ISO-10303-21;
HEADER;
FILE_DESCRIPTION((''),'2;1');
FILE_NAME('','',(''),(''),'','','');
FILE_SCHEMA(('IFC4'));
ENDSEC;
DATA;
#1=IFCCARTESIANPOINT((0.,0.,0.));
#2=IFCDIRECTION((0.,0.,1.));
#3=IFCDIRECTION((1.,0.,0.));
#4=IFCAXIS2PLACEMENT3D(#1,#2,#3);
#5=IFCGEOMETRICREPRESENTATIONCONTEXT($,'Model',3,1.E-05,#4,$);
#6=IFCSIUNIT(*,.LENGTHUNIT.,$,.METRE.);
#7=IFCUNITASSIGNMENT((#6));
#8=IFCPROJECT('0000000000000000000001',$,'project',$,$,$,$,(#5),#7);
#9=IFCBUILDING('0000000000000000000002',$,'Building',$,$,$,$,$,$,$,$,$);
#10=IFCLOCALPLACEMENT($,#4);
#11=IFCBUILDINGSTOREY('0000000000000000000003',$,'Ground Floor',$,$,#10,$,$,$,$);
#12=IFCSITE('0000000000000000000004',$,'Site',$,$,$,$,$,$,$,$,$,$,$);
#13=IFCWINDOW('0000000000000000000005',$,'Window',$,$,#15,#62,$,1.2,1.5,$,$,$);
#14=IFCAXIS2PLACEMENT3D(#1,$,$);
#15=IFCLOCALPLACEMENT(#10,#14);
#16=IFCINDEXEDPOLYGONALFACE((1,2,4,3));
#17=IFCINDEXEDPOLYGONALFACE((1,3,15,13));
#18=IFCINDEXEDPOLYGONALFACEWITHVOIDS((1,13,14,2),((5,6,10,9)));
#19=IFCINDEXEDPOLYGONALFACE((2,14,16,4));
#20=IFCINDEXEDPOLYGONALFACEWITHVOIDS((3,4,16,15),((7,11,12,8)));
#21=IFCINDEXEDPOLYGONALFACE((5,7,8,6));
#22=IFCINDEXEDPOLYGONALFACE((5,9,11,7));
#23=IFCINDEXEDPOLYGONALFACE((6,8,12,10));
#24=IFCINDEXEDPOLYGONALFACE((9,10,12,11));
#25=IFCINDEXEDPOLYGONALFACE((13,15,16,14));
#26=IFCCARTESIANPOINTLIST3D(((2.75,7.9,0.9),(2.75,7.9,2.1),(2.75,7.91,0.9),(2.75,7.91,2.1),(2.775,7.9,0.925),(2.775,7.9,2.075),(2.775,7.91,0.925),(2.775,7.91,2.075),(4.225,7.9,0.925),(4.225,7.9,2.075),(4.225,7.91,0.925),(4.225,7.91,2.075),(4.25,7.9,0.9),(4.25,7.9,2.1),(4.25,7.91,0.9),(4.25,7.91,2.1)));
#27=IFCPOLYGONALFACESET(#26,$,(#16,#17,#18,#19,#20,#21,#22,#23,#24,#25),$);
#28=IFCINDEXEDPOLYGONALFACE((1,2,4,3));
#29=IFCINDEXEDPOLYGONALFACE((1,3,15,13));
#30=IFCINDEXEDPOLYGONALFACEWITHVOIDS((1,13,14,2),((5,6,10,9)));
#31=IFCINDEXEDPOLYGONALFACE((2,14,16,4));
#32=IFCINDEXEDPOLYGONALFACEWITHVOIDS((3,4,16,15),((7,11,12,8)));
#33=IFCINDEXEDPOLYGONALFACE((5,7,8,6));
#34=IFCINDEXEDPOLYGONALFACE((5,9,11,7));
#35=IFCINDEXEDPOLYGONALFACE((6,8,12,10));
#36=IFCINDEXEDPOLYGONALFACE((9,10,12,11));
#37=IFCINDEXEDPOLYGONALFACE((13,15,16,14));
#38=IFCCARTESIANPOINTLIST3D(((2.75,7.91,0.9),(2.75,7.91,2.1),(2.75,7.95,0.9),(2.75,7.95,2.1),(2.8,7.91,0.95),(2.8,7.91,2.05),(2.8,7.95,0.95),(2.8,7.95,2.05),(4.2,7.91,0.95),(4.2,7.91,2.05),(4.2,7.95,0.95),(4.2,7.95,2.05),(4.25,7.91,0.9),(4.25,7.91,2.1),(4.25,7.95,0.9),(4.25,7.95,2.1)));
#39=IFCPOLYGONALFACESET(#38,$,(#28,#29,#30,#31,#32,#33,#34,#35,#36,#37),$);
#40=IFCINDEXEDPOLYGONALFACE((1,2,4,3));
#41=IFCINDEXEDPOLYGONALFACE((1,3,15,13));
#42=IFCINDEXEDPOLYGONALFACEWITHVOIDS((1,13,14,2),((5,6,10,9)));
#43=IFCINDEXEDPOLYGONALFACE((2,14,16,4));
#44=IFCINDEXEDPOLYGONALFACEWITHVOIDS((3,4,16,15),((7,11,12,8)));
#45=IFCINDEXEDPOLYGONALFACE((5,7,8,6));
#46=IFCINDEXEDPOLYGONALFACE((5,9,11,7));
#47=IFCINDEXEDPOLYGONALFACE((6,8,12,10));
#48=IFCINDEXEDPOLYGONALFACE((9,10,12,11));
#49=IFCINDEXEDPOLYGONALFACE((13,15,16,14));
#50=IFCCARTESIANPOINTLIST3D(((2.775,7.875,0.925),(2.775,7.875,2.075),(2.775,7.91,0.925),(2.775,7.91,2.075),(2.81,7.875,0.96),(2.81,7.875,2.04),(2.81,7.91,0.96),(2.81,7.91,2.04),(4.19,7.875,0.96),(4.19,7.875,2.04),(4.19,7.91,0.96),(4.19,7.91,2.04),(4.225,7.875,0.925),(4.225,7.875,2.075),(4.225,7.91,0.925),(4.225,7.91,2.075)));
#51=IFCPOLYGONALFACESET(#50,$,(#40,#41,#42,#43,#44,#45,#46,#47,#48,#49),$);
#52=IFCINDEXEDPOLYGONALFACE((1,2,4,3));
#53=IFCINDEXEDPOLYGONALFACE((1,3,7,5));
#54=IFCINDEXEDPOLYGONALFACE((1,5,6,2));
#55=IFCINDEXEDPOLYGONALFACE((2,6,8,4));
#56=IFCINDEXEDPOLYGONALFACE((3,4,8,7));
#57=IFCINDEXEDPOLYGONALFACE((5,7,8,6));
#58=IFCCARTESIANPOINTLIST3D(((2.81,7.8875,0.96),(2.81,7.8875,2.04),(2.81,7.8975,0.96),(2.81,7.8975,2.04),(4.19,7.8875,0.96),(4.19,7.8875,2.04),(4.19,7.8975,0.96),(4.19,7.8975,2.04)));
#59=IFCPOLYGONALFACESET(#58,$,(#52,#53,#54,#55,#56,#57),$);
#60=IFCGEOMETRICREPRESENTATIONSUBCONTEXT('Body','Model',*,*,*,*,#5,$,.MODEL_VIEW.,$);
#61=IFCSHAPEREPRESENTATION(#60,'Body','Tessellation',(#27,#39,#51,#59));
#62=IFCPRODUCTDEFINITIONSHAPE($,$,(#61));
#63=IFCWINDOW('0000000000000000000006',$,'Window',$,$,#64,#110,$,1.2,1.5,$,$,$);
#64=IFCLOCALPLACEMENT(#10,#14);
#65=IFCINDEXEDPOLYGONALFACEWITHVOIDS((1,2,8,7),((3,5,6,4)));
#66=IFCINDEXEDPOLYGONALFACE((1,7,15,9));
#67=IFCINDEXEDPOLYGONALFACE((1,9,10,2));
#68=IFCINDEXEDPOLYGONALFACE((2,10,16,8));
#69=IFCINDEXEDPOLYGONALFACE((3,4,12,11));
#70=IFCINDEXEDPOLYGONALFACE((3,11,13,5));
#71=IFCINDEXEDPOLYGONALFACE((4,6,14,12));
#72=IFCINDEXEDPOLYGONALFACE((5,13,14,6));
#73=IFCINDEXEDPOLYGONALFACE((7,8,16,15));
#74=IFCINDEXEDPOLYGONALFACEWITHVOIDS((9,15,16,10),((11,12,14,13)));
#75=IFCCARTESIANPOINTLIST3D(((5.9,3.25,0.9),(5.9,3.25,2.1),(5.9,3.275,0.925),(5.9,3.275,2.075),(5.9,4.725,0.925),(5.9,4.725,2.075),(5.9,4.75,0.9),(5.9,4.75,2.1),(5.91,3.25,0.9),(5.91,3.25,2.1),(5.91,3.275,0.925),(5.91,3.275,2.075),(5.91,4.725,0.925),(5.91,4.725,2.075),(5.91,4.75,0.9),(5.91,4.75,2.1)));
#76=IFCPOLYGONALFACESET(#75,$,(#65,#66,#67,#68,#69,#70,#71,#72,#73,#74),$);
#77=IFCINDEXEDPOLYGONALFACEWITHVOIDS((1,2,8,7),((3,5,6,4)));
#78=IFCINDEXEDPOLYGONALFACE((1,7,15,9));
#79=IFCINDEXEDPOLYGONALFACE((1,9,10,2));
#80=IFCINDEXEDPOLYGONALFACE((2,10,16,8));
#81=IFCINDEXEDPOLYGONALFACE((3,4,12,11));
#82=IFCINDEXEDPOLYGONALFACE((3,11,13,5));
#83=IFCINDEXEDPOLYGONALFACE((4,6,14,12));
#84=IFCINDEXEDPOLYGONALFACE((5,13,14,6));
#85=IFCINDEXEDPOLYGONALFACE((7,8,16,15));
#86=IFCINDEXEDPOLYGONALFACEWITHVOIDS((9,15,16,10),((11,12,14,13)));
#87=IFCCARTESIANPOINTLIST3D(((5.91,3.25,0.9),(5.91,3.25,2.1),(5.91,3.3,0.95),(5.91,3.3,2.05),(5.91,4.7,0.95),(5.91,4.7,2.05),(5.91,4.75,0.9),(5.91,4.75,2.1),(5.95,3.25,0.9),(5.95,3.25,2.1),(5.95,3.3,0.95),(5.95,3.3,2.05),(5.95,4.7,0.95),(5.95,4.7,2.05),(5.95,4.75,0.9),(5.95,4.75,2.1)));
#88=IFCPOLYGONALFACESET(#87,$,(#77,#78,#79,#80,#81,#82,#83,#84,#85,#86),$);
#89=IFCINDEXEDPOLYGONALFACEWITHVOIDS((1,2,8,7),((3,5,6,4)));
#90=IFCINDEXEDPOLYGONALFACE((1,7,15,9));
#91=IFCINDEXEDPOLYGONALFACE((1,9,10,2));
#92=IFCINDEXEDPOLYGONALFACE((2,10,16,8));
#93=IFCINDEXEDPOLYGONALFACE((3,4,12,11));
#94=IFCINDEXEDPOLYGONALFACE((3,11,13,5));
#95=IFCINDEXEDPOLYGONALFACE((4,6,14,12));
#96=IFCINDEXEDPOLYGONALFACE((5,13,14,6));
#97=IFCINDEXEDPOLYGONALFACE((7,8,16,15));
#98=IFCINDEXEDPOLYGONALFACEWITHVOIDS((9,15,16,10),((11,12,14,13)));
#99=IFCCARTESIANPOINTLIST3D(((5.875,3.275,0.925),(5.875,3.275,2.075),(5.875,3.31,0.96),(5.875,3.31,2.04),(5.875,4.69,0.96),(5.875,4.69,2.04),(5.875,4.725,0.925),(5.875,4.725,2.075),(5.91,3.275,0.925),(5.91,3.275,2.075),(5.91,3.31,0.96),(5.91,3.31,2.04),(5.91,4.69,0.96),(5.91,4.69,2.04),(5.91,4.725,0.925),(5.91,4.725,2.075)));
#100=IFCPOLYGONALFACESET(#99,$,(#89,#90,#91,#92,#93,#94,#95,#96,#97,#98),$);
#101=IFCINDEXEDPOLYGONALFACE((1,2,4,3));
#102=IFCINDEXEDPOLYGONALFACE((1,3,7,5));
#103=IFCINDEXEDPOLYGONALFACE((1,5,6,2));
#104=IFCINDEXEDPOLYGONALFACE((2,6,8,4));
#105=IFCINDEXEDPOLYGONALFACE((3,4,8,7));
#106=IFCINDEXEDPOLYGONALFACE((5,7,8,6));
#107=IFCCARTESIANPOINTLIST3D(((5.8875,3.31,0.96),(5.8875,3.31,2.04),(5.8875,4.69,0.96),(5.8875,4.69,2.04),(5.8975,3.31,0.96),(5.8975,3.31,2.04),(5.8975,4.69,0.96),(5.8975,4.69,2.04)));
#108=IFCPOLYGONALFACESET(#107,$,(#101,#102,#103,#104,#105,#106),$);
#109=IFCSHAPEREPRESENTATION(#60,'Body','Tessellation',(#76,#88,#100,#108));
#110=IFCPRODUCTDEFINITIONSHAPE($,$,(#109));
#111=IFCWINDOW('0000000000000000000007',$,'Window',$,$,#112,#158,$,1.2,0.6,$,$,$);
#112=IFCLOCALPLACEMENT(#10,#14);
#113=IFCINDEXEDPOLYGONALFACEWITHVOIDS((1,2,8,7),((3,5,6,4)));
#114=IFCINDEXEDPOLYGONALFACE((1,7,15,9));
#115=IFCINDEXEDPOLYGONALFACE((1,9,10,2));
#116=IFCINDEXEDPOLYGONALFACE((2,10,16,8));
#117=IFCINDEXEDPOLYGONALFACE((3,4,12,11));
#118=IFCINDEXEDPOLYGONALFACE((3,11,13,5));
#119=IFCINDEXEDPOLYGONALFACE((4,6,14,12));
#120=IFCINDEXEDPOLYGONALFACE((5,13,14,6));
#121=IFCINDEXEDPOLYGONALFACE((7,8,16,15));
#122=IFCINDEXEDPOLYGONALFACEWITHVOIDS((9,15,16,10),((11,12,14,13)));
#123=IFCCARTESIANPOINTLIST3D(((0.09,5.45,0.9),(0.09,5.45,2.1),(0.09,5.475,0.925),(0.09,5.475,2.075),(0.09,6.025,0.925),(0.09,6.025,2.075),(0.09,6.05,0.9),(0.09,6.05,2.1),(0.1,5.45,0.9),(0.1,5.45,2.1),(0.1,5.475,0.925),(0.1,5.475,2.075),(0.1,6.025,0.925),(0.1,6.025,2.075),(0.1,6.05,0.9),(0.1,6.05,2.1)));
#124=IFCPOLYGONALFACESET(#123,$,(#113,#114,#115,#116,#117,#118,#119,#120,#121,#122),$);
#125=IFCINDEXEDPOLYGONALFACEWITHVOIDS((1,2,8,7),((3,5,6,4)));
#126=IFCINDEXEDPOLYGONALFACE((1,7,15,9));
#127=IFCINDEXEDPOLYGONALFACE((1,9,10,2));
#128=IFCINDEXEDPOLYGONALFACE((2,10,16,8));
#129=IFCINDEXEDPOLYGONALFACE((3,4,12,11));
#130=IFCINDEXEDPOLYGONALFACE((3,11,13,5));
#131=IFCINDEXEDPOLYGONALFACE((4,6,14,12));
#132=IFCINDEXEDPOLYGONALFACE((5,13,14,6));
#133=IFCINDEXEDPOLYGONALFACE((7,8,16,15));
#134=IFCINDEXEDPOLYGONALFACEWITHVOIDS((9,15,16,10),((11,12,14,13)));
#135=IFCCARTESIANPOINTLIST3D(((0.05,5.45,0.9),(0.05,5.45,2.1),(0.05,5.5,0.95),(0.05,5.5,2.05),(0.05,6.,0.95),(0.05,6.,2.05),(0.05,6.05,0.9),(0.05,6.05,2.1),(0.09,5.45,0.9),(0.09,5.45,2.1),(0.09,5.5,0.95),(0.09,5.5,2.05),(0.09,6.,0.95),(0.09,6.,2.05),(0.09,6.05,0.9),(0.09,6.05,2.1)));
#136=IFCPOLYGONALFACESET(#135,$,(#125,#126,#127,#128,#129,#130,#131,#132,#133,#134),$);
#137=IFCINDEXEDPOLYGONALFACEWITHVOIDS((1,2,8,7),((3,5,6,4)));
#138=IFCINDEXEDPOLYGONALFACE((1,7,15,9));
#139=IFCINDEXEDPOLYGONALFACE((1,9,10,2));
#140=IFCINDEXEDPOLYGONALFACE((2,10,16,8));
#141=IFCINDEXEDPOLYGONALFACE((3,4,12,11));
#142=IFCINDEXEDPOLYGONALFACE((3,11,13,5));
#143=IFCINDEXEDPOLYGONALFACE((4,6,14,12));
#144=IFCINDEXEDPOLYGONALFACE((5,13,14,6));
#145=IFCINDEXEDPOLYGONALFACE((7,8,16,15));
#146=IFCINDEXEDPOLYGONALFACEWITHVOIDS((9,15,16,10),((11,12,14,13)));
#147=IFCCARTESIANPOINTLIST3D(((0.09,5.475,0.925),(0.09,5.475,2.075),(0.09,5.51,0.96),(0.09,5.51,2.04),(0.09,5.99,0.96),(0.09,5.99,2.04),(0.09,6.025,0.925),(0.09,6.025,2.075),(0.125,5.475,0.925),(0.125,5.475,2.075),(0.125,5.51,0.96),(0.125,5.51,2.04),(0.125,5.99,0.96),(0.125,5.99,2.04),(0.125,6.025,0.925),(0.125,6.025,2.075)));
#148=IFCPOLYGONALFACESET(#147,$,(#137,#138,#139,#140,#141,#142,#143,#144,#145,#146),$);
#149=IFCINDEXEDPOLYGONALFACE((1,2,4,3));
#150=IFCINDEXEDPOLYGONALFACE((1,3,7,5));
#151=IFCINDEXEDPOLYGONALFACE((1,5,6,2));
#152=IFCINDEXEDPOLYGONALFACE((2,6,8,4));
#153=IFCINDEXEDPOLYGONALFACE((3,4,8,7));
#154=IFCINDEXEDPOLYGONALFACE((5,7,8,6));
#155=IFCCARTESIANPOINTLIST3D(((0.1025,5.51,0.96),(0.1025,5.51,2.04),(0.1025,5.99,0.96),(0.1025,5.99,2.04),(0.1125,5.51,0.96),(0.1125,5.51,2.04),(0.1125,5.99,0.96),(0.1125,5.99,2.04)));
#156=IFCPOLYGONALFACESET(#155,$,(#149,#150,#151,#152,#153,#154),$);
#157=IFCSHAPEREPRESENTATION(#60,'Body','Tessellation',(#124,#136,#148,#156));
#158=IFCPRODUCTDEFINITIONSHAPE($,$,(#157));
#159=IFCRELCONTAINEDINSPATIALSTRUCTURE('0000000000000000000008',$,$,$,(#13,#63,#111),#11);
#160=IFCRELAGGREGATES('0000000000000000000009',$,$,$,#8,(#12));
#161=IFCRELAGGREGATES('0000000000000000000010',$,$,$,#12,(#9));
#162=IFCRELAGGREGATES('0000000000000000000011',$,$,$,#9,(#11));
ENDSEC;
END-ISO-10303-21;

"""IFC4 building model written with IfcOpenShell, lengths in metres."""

from ifc_helpers import new_model, si_unit, frame, origin_with_axes, place, context, subcontext, project, spatial, line, indexed_curve, outline, extrude, element, save


model = new_model("IFC4")

# Units and contexts
model_context = context("Model", 3, precision=1e-05, world=origin_with_axes())
body_context = subcontext(model_context, "Body", "Model", "MODEL_VIEW")
ifc_project = project(units=[si_unit("LENGTHUNIT", "METRE")], contexts=[model_context])

# Site, building, storey
site = spatial("IfcSite", under=ifc_project, Name="Site")
building = spatial("IfcBuilding", under=site, Name="Building")
storey_placement = place(None, origin_with_axes())
storey = spatial("IfcBuildingStorey", under=building, at=storey_placement, Name="Ground Floor")

# Windows
for number, where, z_axis, x_axis, name in (
    (1, (4.25, 8.0, 0.9), (0.0, 0.0, 1.0), (-1.0, 0.0, 0.0), "Window"),
    (2, (6.0, 3.25, 0.9), (0.0, 0.0, 1.0), (0.0, 1.0, 0.0), "Window"),
):
    element("IfcWindow", number, at=place(storey_placement, frame(where, z_axis=z_axis, x_axis=x_axis)), inside=storey, Name=name, OverallHeight=1.2, OverallWidth=1.5, context=body_context, shape_type="SweptSolid", body=[
        extrude(outline(indexed_curve([(0.0, 0.0), (1.5, 0.0), (1.5, 1.2), (0.0, 1.2)], segments=[line(1, 2, 3, 4, 1)]), holes=[indexed_curve([(0.025, 0.025), (1.475, 0.025), (1.475, 1.175), (0.025, 1.175)], segments=[line(1, 2, 3, 4, 1)])]), frame((0.0, 0.09, 0.0), z_axis=(0.0, -1.0, 0.0), x_axis=(1.0, 0.0, 0.0)), (0.0, 0.0, -1.0), 0.01),
        extrude(outline(indexed_curve([(0.0, 0.0), (1.5, 0.0), (1.5, 1.2), (0.0, 1.2)], segments=[line(1, 2, 3, 4, 1)]), holes=[indexed_curve([(0.05, 0.05), (1.45, 0.05), (1.45, 1.15), (0.05, 1.15)], segments=[line(1, 2, 3, 4, 1)])]), frame((0.0, 0.05, 0.0), z_axis=(0.0, -1.0, 0.0), x_axis=(1.0, 0.0, 0.0)), (0.0, 0.0, -1.0), 0.04),
        extrude(outline(indexed_curve([(0.0, 0.0), (1.45, 0.0), (1.45, 1.15), (0.0, 1.15)], segments=[line(1, 2, 3, 4, 1)]), holes=[indexed_curve([(0.035, 0.035), (1.415, 0.035), (1.415, 1.115), (0.035, 1.115)], segments=[line(1, 2, 3, 4, 1)])]), frame((0.025, 0.09, 0.025), z_axis=(0.0, -1.0, 0.0), x_axis=(1.0, 0.0, 0.0)), (0.0, 0.0, -1.0), 0.035),
        extrude(outline(indexed_curve([(0.035, 0.035), (1.415, 0.035), (1.415, 1.115), (0.035, 1.115)], segments=[line(1, 2, 3, 4, 1)])), frame((0.025, 0.1025, 0.025), z_axis=(0.0, -1.0, 0.0), x_axis=(1.0, 0.0, 0.0)), (0.0, 0.0, -1.0), 0.01),
    ])
window_1_placement = place(storey_placement, frame((0.0, 6.05, 0.9), z_axis=(0.0, 0.0, 1.0), x_axis=(0.0, -1.0, 0.0)))
element("IfcWindow", 3, at=window_1_placement, inside=storey, Name="Window", OverallHeight=1.2, OverallWidth=0.6, context=body_context, shape_type="SweptSolid", body=[
    extrude(outline(indexed_curve([(0.0, 0.0), (0.6, 0.0), (0.6, 1.2), (0.0, 1.2)], segments=[line(1, 2, 3, 4, 1)]), holes=[indexed_curve([(0.025, 0.025), (0.575, 0.025), (0.575, 1.175), (0.025, 1.175)], segments=[line(1, 2, 3, 4, 1)])]), frame((0.0, 0.09, 0.0), z_axis=(0.0, -1.0, 0.0), x_axis=(1.0, 0.0, 0.0)), (0.0, 0.0, -1.0), 0.01),
    extrude(outline(indexed_curve([(0.0, 0.0), (0.6, 0.0), (0.6, 1.2), (0.0, 1.2)], segments=[line(1, 2, 3, 4, 1)]), holes=[indexed_curve([(0.05, 0.05), (0.55, 0.05), (0.55, 1.15), (0.05, 1.15)], segments=[line(1, 2, 3, 4, 1)])]), frame((0.0, 0.05, 0.0), z_axis=(0.0, -1.0, 0.0), x_axis=(1.0, 0.0, 0.0)), (0.0, 0.0, -1.0), 0.04),
    extrude(outline(indexed_curve([(0.0, 0.0), (0.55, 0.0), (0.55, 1.15), (0.0, 1.15)], segments=[line(1, 2, 3, 4, 1)]), holes=[indexed_curve([(0.035, 0.035), (0.515, 0.035), (0.515, 1.115), (0.035, 1.115)], segments=[line(1, 2, 3, 4, 1)])]), frame((0.025, 0.09, 0.025), z_axis=(0.0, -1.0, 0.0), x_axis=(1.0, 0.0, 0.0)), (0.0, 0.0, -1.0), 0.035),
    extrude(outline(indexed_curve([(0.035, 0.035), (0.515, 0.035), (0.515, 1.115), (0.035, 1.115)], segments=[line(1, 2, 3, 4, 1)])), frame((0.025, 0.1025, 0.025), z_axis=(0.0, -1.0, 0.0), x_axis=(1.0, 0.0, 0.0)), (0.0, 0.0, -1.0), 0.01),
])

save(model, "model.ifc")
